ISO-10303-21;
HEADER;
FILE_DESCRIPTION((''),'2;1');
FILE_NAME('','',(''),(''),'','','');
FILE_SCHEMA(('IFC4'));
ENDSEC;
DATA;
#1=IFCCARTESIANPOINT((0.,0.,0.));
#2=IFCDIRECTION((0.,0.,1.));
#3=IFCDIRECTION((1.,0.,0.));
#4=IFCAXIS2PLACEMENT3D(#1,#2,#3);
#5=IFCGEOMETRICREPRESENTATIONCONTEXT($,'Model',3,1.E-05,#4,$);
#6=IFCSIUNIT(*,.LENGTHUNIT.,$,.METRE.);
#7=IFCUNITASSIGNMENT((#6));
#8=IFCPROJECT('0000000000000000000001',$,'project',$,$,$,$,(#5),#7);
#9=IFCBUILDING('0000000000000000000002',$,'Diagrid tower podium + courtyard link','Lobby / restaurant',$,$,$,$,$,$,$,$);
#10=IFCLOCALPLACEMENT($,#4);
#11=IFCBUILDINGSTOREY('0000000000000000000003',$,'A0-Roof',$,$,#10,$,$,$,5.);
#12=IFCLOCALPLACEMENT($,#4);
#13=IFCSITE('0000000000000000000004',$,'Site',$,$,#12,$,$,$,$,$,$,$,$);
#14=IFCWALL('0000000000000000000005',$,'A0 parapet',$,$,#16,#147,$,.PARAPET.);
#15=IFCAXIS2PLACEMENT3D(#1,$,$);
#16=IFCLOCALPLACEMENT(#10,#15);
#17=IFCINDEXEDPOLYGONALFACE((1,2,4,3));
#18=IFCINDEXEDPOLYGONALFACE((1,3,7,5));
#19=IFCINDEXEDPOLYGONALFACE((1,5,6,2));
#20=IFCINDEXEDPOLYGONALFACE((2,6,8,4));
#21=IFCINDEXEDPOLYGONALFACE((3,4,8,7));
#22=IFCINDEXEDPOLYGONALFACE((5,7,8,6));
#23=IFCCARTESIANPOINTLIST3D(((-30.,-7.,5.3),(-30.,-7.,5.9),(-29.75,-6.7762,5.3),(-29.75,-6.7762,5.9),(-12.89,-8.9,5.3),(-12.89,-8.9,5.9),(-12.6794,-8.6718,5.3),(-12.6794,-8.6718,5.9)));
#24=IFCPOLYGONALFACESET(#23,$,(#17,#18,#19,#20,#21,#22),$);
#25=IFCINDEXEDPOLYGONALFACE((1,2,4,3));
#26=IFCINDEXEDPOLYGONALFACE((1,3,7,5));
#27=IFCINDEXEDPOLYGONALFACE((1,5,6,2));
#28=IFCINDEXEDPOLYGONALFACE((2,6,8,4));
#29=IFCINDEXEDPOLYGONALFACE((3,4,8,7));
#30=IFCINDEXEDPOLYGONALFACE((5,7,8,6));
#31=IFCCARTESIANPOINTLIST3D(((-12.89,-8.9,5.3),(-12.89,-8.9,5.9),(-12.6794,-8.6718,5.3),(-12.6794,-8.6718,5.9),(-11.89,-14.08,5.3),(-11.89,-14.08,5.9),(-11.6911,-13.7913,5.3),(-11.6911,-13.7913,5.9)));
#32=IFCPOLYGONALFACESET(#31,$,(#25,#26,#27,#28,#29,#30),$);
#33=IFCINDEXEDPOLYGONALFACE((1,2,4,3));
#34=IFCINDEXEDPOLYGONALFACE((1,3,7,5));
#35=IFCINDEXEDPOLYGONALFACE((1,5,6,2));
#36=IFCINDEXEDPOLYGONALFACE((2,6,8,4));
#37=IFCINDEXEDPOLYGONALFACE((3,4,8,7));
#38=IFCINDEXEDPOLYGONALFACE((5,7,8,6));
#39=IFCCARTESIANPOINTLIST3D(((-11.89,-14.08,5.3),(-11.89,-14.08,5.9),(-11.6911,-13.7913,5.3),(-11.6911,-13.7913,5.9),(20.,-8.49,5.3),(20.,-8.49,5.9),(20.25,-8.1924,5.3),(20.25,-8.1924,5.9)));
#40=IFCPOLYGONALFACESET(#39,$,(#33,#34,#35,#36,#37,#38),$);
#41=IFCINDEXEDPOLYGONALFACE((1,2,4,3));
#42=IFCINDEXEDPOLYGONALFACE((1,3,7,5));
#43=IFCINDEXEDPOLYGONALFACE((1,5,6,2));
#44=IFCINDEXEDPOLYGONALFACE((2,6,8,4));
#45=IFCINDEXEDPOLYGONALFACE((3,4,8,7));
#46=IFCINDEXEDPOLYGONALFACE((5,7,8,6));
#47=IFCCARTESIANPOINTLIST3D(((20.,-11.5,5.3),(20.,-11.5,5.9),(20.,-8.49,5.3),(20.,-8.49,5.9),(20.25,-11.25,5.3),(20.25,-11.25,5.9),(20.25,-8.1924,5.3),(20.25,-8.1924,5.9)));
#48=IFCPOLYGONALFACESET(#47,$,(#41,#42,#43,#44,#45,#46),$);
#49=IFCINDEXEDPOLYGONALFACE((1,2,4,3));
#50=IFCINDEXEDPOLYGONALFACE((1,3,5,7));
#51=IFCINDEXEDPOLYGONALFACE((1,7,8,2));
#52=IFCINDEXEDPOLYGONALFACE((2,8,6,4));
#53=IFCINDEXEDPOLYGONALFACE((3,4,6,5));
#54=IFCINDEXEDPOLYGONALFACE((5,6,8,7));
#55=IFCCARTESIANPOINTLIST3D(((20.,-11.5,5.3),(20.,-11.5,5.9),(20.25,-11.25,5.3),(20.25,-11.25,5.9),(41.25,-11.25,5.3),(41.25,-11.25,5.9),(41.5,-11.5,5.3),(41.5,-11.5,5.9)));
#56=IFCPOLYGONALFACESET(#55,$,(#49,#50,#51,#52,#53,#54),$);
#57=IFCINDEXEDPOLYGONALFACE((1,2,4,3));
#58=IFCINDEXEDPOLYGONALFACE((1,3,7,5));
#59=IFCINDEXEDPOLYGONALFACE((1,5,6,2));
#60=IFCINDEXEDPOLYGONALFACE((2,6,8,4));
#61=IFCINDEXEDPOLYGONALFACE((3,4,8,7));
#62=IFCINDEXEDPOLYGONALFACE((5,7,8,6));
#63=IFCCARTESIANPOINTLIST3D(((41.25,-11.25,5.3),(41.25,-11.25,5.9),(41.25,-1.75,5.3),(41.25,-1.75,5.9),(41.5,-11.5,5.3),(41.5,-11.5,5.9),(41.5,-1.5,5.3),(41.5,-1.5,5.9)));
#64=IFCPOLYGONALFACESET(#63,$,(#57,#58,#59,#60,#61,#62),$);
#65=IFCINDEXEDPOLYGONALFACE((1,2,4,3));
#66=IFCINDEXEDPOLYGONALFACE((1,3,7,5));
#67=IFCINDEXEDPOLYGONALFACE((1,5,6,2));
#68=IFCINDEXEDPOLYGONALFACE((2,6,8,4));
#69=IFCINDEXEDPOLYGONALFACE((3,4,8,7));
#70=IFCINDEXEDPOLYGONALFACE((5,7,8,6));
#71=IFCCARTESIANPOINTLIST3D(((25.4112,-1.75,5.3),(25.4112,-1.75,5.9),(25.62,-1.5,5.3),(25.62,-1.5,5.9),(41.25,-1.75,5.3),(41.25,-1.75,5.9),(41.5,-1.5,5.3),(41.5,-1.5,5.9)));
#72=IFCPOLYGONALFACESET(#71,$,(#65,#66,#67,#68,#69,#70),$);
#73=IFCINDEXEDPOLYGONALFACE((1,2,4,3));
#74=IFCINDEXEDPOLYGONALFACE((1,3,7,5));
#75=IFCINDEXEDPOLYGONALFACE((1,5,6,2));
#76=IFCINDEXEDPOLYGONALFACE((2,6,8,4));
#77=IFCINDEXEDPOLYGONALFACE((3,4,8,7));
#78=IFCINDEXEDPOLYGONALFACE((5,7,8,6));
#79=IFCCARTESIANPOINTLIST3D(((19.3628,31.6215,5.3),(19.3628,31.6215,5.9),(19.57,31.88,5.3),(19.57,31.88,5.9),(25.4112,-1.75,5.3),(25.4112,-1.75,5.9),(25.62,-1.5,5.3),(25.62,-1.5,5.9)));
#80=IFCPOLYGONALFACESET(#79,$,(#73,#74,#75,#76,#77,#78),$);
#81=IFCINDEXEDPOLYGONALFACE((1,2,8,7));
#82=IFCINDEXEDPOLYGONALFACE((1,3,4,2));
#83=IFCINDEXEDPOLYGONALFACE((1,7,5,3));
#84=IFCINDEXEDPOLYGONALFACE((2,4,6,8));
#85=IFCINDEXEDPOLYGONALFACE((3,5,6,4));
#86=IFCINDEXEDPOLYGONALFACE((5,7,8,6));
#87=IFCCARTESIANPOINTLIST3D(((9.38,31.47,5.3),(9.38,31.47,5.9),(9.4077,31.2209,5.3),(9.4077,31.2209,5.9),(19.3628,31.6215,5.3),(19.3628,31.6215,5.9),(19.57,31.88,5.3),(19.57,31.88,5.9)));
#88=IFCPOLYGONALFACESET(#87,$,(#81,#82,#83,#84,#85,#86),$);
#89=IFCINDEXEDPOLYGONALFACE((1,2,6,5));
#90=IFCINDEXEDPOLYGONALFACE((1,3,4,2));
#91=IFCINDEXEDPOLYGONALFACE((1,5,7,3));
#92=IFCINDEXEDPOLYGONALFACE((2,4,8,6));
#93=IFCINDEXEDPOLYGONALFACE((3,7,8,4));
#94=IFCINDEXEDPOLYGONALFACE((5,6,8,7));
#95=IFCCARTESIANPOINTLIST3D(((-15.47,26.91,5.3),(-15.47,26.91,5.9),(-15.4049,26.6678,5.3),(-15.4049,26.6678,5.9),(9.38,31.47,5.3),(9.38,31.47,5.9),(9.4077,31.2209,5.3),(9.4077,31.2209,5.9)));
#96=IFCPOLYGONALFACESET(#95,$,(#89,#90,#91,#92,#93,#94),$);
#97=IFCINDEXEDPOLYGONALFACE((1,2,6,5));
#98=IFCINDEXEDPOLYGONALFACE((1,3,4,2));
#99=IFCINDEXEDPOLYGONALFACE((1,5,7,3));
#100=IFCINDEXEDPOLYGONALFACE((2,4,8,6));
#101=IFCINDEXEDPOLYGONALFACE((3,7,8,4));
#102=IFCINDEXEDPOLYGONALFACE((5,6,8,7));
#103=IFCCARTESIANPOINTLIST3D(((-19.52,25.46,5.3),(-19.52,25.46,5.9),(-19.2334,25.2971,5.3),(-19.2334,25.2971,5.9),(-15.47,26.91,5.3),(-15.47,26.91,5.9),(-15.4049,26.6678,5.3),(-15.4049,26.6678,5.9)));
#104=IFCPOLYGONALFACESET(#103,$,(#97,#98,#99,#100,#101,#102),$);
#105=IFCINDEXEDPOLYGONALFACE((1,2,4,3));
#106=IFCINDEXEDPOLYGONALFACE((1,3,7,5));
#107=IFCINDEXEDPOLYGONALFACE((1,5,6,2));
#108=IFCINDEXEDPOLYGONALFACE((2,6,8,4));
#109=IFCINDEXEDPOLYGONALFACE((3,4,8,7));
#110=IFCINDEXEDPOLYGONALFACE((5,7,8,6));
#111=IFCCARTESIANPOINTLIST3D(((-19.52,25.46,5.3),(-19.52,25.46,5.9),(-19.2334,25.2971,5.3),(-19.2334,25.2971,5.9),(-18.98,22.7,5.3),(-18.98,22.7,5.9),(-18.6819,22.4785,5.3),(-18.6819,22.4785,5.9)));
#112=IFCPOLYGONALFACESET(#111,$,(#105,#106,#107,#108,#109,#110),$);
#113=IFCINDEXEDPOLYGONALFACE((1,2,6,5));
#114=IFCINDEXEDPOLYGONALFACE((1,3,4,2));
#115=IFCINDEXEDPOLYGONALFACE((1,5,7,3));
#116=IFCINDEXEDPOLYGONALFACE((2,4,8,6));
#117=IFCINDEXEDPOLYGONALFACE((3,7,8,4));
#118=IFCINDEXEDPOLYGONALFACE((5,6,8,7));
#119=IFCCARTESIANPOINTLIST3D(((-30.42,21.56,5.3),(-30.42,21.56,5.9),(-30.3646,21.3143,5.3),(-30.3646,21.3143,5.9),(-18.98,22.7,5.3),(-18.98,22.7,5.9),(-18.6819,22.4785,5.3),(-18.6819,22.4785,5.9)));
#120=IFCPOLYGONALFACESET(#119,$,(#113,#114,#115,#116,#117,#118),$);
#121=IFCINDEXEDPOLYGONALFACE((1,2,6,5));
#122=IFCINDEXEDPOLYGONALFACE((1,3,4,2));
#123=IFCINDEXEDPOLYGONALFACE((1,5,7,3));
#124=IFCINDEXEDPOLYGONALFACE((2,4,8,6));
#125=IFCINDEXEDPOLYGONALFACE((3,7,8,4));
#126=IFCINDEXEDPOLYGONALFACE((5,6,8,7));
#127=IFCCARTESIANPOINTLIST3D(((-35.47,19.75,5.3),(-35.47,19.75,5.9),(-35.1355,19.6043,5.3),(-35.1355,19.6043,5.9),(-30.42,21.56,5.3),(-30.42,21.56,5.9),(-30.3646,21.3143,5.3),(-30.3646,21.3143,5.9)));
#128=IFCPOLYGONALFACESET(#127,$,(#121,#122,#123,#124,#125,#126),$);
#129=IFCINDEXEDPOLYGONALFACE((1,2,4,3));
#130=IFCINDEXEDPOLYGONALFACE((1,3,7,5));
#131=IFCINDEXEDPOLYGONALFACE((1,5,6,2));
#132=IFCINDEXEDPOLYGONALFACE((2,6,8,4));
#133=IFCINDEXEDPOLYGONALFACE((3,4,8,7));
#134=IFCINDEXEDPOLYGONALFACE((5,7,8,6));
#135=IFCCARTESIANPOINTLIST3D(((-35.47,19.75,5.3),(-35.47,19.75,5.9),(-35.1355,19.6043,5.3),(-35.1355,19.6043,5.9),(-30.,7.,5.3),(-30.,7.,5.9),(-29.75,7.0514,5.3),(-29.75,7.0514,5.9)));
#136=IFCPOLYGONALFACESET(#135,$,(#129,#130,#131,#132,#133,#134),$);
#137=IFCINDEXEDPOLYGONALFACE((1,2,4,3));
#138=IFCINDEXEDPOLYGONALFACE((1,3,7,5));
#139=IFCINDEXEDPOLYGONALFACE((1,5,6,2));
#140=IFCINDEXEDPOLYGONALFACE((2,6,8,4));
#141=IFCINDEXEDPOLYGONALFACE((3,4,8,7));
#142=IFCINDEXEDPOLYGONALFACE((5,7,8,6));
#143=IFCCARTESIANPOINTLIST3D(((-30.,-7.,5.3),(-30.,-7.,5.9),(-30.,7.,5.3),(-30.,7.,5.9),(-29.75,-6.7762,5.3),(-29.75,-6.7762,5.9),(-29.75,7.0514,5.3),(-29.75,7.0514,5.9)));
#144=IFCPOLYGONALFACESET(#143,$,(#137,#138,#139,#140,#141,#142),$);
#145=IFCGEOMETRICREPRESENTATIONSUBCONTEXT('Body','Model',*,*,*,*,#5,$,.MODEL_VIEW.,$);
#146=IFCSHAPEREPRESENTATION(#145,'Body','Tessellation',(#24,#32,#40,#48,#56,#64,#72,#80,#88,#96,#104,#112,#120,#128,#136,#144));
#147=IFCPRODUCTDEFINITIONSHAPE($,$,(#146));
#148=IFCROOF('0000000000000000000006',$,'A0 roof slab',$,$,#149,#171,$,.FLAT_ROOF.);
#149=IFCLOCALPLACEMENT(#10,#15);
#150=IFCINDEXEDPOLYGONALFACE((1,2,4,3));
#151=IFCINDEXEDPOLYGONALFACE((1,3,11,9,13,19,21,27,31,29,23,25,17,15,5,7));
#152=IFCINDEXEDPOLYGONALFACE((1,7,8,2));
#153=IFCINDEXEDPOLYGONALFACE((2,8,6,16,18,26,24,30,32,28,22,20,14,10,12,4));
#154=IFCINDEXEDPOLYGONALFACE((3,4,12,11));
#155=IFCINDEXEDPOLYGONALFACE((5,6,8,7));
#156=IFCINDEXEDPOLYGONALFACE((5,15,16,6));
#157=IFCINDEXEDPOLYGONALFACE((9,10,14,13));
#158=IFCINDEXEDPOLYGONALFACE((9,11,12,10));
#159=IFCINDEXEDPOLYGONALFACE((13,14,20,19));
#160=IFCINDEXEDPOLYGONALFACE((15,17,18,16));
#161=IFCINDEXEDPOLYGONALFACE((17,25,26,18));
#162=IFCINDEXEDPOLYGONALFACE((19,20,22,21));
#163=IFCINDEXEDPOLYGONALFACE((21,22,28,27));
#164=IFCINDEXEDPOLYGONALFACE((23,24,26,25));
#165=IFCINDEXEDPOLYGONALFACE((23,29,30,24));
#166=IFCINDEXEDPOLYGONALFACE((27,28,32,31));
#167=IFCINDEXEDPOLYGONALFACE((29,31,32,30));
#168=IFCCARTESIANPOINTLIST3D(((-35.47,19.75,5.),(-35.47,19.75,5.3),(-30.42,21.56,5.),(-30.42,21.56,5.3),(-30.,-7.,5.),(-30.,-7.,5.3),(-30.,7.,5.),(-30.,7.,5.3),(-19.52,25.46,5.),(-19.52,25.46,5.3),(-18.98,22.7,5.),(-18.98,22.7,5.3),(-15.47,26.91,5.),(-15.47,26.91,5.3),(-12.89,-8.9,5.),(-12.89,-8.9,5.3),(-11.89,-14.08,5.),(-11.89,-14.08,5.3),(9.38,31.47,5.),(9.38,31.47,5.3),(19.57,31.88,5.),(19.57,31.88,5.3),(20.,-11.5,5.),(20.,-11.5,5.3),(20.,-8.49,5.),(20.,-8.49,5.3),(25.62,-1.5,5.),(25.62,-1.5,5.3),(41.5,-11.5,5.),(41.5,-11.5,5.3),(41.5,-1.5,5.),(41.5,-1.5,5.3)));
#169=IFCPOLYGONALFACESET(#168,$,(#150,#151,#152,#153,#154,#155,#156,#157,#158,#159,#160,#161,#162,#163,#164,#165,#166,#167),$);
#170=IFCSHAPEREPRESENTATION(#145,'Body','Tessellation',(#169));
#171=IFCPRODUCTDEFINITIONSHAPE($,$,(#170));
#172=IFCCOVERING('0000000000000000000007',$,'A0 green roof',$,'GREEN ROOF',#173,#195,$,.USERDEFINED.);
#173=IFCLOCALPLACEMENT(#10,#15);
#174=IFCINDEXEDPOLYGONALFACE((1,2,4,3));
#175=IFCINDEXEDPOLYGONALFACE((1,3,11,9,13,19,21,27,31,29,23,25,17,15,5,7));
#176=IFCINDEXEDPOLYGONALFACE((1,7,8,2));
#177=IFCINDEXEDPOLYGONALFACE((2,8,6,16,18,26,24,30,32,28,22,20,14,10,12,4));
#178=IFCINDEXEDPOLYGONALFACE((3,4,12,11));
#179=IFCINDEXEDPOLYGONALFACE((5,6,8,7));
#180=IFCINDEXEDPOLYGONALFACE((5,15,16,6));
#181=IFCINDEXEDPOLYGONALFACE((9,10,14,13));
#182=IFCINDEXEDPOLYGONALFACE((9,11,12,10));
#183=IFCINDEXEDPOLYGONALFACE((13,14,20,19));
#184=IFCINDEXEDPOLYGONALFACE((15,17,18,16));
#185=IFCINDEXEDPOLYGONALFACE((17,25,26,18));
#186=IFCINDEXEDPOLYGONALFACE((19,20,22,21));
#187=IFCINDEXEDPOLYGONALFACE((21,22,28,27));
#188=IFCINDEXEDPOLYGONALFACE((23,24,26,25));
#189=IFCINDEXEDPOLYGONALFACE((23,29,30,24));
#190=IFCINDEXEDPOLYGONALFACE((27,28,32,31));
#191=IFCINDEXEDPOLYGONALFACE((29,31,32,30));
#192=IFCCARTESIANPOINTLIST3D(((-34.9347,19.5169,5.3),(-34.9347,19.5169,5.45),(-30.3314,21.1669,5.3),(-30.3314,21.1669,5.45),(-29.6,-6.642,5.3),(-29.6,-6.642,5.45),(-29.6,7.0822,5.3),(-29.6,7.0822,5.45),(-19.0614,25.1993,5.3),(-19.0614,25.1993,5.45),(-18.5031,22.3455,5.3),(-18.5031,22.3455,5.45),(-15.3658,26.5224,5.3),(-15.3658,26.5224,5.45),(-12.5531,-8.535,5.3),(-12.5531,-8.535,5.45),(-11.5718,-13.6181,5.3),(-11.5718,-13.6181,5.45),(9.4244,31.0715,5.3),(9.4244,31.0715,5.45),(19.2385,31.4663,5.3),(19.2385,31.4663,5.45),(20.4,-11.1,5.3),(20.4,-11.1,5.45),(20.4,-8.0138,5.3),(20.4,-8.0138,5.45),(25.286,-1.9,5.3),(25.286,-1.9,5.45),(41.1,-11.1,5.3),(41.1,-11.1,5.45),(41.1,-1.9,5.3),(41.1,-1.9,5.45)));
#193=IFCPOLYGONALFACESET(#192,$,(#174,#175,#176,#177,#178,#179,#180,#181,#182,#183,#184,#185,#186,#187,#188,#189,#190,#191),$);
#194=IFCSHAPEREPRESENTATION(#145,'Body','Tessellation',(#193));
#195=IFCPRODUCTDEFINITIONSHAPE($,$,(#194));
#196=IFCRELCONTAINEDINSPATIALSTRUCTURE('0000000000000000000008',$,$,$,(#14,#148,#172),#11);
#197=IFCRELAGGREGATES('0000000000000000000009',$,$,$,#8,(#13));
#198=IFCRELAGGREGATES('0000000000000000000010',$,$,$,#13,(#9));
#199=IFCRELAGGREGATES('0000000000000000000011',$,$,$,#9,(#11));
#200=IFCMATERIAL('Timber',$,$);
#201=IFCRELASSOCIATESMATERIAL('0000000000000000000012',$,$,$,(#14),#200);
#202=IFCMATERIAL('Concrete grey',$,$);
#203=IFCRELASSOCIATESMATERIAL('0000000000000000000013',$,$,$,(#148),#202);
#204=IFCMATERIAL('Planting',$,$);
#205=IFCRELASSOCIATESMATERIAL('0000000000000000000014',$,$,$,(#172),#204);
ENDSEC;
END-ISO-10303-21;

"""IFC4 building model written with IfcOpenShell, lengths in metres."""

from ifc_helpers import new_model, si_unit, frame, origin_with_axes, place, context, subcontext, project, spatial, polyline, outline, extrude, material, element, save


model = new_model("IFC4")

# Units and contexts
model_context = context("Model", 3, precision=1e-05, world=origin_with_axes())
body_context = subcontext(model_context, "Body", "Model", "MODEL_VIEW")
ifc_project = project(units=[si_unit("LENGTHUNIT", "METRE")], contexts=[model_context])

# Site, building, storey
site_placement = place(None, origin_with_axes())
site = spatial("IfcSite", under=ifc_project, at=site_placement, Name="Site")
building = spatial("IfcBuilding", under=site, Name="Diagrid tower podium + courtyard link", Description="Lobby / restaurant")
storey_placement = place(None, origin_with_axes())
storey = spatial("IfcBuildingStorey", under=building, at=storey_placement, Name="A0-Roof", Elevation=5.0)

# Wall
ifc_material_1 = material(Name="Timber")
wall_placement = place(storey_placement, origin_with_axes())
element("IfcWall", 1, at=wall_placement, inside=storey, material=ifc_material_1, Name="A0 parapet", PredefinedType="PARAPET", context=body_context, shape_type="SweptSolid", body=[
    extrude(outline(polyline([(-30.0, -7.0), (-12.89, -8.9), (-12.6794, -8.6718), (-29.75, -6.7762), (-30.0, -7.0)])), frame((0.0, 0.0, 5.3), z_axis=(0.0, 0.0, 1.0), x_axis=(1.0, 0.0, 0.0)), (0.0, 0.0, 1.0), 0.6),
    extrude(outline(polyline([(-12.89, -8.9), (-11.89, -14.08), (-11.6911, -13.7913), (-12.6794, -8.6718), (-12.89, -8.9)])), frame((0.0, 0.0, 5.3), z_axis=(0.0, 0.0, 1.0), x_axis=(1.0, 0.0, 0.0)), (0.0, 0.0, 1.0), 0.6),
    extrude(outline(polyline([(-11.89, -14.08), (20.0, -8.49), (20.25, -8.1924), (-11.6911, -13.7913), (-11.89, -14.08)])), frame((0.0, 0.0, 5.3), z_axis=(0.0, 0.0, 1.0), x_axis=(1.0, 0.0, 0.0)), (0.0, 0.0, 1.0), 0.6),
    extrude(outline(polyline([(20.0, -8.49), (20.0, -11.5), (20.25, -11.25), (20.25, -8.1924), (20.0, -8.49)])), frame((0.0, 0.0, 5.3), z_axis=(0.0, 0.0, 1.0), x_axis=(1.0, 0.0, 0.0)), (0.0, 0.0, 1.0), 0.6),
    extrude(outline(polyline([(20.0, -11.5), (41.5, -11.5), (41.25, -11.25), (20.25, -11.25), (20.0, -11.5)])), frame((0.0, 0.0, 5.3), z_axis=(0.0, 0.0, 1.0), x_axis=(1.0, 0.0, 0.0)), (0.0, 0.0, 1.0), 0.6),
    extrude(outline(polyline([(41.5, -11.5), (41.5, -1.5), (41.25, -1.75), (41.25, -11.25), (41.5, -11.5)])), frame((0.0, 0.0, 5.3), z_axis=(0.0, 0.0, 1.0), x_axis=(1.0, 0.0, 0.0)), (0.0, 0.0, 1.0), 0.6),
    extrude(outline(polyline([(41.5, -1.5), (25.62, -1.5), (25.4112, -1.75), (41.25, -1.75), (41.5, -1.5)])), frame((0.0, 0.0, 5.3), z_axis=(0.0, 0.0, 1.0), x_axis=(1.0, 0.0, 0.0)), (0.0, 0.0, 1.0), 0.6),
    extrude(outline(polyline([(25.62, -1.5), (19.57, 31.88), (19.3628, 31.6215), (25.4112, -1.75), (25.62, -1.5)])), frame((0.0, 0.0, 5.3), z_axis=(0.0, 0.0, 1.0), x_axis=(1.0, 0.0, 0.0)), (0.0, 0.0, 1.0), 0.6),
    extrude(outline(polyline([(19.57, 31.88), (9.38, 31.47), (9.4077, 31.2209), (19.3628, 31.6215), (19.57, 31.88)])), frame((0.0, 0.0, 5.3), z_axis=(0.0, 0.0, 1.0), x_axis=(1.0, 0.0, 0.0)), (0.0, 0.0, 1.0), 0.6),
    extrude(outline(polyline([(9.38, 31.47), (-15.47, 26.91), (-15.4049, 26.6678), (9.4077, 31.2209), (9.38, 31.47)])), frame((0.0, 0.0, 5.3), z_axis=(0.0, 0.0, 1.0), x_axis=(1.0, 0.0, 0.0)), (0.0, 0.0, 1.0), 0.6),
    extrude(outline(polyline([(-15.47, 26.91), (-19.52, 25.46), (-19.2334, 25.2971), (-15.4049, 26.6678), (-15.47, 26.91)])), frame((0.0, 0.0, 5.3), z_axis=(0.0, 0.0, 1.0), x_axis=(1.0, 0.0, 0.0)), (0.0, 0.0, 1.0), 0.6),
    extrude(outline(polyline([(-19.52, 25.46), (-18.98, 22.7), (-18.6819, 22.4785), (-19.2334, 25.2971), (-19.52, 25.46)])), frame((0.0, 0.0, 5.3), z_axis=(0.0, 0.0, 1.0), x_axis=(1.0, 0.0, 0.0)), (0.0, 0.0, 1.0), 0.6),
    extrude(outline(polyline([(-18.98, 22.7), (-30.42, 21.56), (-30.3646, 21.3143), (-18.6819, 22.4785), (-18.98, 22.7)])), frame((0.0, 0.0, 5.3), z_axis=(0.0, 0.0, 1.0), x_axis=(1.0, 0.0, 0.0)), (0.0, 0.0, 1.0), 0.6),
    extrude(outline(polyline([(-30.42, 21.56), (-35.47, 19.75), (-35.1355, 19.6043), (-30.3646, 21.3143), (-30.42, 21.56)])), frame((0.0, 0.0, 5.3), z_axis=(0.0, 0.0, 1.0), x_axis=(1.0, 0.0, 0.0)), (0.0, 0.0, 1.0), 0.6),
    extrude(outline(polyline([(-35.47, 19.75), (-30.0, 7.0), (-29.75, 7.0514), (-35.1355, 19.6043), (-35.47, 19.75)])), frame((0.0, 0.0, 5.3), z_axis=(0.0, 0.0, 1.0), x_axis=(1.0, 0.0, 0.0)), (0.0, 0.0, 1.0), 0.6),
    extrude(outline(polyline([(-30.0, 7.0), (-30.0, -7.0), (-29.75, -6.7762), (-29.75, 7.0514), (-30.0, 7.0)])), frame((0.0, 0.0, 5.3), z_axis=(0.0, 0.0, 1.0), x_axis=(1.0, 0.0, 0.0)), (0.0, 0.0, 1.0), 0.6),
])

# Roof
ifc_material_2 = material(Name="Concrete grey")
roof_placement = place(storey_placement, origin_with_axes())
element("IfcRoof", 2, at=roof_placement, inside=storey, material=ifc_material_2, Name="A0 roof slab", PredefinedType="FLAT_ROOF", context=body_context, shape_type="SweptSolid", body=[
    extrude(outline(polyline([(-30.0, -7.0), (-12.89, -8.9), (-11.89, -14.08), (20.0, -8.49), (20.0, -11.5), (41.5, -11.5), (41.5, -1.5), (25.62, -1.5), (19.57, 31.88), (9.38, 31.47), (-15.47, 26.91), (-19.52, 25.46), (-18.98, 22.7), (-30.42, 21.56), (-35.47, 19.75), (-30.0, 7.0), (-30.0, -7.0)])), frame((0.0, 0.0, 5.0), z_axis=(0.0, 0.0, 1.0), x_axis=(1.0, 0.0, 0.0)), (0.0, 0.0, 1.0), 0.3),
])

# Covering
ifc_material_3 = material(Name="Planting")
covering_placement = place(storey_placement, origin_with_axes())
element("IfcCovering", 3, at=covering_placement, inside=storey, material=ifc_material_3, Name="A0 green roof", ObjectType="GREEN ROOF", PredefinedType="USERDEFINED", context=body_context, shape_type="SweptSolid", body=[
    extrude(outline(polyline([(-29.6, -6.642), (-12.5531, -8.535), (-11.5718, -13.6181), (20.4, -8.0138), (20.4, -11.1), (41.1, -11.1), (41.1, -1.9), (25.286, -1.9), (19.2385, 31.4663), (9.4244, 31.0715), (-15.3658, 26.5224), (-19.0614, 25.1993), (-18.5031, 22.3455), (-30.3314, 21.1669), (-34.9347, 19.5169), (-29.6, 7.0822), (-29.6, -6.642)])), frame((0.0, 0.0, 5.3), z_axis=(0.0, 0.0, 1.0), x_axis=(1.0, 0.0, 0.0)), (0.0, 0.0, 1.0), 0.15),
])

save(model, "model.ifc")
